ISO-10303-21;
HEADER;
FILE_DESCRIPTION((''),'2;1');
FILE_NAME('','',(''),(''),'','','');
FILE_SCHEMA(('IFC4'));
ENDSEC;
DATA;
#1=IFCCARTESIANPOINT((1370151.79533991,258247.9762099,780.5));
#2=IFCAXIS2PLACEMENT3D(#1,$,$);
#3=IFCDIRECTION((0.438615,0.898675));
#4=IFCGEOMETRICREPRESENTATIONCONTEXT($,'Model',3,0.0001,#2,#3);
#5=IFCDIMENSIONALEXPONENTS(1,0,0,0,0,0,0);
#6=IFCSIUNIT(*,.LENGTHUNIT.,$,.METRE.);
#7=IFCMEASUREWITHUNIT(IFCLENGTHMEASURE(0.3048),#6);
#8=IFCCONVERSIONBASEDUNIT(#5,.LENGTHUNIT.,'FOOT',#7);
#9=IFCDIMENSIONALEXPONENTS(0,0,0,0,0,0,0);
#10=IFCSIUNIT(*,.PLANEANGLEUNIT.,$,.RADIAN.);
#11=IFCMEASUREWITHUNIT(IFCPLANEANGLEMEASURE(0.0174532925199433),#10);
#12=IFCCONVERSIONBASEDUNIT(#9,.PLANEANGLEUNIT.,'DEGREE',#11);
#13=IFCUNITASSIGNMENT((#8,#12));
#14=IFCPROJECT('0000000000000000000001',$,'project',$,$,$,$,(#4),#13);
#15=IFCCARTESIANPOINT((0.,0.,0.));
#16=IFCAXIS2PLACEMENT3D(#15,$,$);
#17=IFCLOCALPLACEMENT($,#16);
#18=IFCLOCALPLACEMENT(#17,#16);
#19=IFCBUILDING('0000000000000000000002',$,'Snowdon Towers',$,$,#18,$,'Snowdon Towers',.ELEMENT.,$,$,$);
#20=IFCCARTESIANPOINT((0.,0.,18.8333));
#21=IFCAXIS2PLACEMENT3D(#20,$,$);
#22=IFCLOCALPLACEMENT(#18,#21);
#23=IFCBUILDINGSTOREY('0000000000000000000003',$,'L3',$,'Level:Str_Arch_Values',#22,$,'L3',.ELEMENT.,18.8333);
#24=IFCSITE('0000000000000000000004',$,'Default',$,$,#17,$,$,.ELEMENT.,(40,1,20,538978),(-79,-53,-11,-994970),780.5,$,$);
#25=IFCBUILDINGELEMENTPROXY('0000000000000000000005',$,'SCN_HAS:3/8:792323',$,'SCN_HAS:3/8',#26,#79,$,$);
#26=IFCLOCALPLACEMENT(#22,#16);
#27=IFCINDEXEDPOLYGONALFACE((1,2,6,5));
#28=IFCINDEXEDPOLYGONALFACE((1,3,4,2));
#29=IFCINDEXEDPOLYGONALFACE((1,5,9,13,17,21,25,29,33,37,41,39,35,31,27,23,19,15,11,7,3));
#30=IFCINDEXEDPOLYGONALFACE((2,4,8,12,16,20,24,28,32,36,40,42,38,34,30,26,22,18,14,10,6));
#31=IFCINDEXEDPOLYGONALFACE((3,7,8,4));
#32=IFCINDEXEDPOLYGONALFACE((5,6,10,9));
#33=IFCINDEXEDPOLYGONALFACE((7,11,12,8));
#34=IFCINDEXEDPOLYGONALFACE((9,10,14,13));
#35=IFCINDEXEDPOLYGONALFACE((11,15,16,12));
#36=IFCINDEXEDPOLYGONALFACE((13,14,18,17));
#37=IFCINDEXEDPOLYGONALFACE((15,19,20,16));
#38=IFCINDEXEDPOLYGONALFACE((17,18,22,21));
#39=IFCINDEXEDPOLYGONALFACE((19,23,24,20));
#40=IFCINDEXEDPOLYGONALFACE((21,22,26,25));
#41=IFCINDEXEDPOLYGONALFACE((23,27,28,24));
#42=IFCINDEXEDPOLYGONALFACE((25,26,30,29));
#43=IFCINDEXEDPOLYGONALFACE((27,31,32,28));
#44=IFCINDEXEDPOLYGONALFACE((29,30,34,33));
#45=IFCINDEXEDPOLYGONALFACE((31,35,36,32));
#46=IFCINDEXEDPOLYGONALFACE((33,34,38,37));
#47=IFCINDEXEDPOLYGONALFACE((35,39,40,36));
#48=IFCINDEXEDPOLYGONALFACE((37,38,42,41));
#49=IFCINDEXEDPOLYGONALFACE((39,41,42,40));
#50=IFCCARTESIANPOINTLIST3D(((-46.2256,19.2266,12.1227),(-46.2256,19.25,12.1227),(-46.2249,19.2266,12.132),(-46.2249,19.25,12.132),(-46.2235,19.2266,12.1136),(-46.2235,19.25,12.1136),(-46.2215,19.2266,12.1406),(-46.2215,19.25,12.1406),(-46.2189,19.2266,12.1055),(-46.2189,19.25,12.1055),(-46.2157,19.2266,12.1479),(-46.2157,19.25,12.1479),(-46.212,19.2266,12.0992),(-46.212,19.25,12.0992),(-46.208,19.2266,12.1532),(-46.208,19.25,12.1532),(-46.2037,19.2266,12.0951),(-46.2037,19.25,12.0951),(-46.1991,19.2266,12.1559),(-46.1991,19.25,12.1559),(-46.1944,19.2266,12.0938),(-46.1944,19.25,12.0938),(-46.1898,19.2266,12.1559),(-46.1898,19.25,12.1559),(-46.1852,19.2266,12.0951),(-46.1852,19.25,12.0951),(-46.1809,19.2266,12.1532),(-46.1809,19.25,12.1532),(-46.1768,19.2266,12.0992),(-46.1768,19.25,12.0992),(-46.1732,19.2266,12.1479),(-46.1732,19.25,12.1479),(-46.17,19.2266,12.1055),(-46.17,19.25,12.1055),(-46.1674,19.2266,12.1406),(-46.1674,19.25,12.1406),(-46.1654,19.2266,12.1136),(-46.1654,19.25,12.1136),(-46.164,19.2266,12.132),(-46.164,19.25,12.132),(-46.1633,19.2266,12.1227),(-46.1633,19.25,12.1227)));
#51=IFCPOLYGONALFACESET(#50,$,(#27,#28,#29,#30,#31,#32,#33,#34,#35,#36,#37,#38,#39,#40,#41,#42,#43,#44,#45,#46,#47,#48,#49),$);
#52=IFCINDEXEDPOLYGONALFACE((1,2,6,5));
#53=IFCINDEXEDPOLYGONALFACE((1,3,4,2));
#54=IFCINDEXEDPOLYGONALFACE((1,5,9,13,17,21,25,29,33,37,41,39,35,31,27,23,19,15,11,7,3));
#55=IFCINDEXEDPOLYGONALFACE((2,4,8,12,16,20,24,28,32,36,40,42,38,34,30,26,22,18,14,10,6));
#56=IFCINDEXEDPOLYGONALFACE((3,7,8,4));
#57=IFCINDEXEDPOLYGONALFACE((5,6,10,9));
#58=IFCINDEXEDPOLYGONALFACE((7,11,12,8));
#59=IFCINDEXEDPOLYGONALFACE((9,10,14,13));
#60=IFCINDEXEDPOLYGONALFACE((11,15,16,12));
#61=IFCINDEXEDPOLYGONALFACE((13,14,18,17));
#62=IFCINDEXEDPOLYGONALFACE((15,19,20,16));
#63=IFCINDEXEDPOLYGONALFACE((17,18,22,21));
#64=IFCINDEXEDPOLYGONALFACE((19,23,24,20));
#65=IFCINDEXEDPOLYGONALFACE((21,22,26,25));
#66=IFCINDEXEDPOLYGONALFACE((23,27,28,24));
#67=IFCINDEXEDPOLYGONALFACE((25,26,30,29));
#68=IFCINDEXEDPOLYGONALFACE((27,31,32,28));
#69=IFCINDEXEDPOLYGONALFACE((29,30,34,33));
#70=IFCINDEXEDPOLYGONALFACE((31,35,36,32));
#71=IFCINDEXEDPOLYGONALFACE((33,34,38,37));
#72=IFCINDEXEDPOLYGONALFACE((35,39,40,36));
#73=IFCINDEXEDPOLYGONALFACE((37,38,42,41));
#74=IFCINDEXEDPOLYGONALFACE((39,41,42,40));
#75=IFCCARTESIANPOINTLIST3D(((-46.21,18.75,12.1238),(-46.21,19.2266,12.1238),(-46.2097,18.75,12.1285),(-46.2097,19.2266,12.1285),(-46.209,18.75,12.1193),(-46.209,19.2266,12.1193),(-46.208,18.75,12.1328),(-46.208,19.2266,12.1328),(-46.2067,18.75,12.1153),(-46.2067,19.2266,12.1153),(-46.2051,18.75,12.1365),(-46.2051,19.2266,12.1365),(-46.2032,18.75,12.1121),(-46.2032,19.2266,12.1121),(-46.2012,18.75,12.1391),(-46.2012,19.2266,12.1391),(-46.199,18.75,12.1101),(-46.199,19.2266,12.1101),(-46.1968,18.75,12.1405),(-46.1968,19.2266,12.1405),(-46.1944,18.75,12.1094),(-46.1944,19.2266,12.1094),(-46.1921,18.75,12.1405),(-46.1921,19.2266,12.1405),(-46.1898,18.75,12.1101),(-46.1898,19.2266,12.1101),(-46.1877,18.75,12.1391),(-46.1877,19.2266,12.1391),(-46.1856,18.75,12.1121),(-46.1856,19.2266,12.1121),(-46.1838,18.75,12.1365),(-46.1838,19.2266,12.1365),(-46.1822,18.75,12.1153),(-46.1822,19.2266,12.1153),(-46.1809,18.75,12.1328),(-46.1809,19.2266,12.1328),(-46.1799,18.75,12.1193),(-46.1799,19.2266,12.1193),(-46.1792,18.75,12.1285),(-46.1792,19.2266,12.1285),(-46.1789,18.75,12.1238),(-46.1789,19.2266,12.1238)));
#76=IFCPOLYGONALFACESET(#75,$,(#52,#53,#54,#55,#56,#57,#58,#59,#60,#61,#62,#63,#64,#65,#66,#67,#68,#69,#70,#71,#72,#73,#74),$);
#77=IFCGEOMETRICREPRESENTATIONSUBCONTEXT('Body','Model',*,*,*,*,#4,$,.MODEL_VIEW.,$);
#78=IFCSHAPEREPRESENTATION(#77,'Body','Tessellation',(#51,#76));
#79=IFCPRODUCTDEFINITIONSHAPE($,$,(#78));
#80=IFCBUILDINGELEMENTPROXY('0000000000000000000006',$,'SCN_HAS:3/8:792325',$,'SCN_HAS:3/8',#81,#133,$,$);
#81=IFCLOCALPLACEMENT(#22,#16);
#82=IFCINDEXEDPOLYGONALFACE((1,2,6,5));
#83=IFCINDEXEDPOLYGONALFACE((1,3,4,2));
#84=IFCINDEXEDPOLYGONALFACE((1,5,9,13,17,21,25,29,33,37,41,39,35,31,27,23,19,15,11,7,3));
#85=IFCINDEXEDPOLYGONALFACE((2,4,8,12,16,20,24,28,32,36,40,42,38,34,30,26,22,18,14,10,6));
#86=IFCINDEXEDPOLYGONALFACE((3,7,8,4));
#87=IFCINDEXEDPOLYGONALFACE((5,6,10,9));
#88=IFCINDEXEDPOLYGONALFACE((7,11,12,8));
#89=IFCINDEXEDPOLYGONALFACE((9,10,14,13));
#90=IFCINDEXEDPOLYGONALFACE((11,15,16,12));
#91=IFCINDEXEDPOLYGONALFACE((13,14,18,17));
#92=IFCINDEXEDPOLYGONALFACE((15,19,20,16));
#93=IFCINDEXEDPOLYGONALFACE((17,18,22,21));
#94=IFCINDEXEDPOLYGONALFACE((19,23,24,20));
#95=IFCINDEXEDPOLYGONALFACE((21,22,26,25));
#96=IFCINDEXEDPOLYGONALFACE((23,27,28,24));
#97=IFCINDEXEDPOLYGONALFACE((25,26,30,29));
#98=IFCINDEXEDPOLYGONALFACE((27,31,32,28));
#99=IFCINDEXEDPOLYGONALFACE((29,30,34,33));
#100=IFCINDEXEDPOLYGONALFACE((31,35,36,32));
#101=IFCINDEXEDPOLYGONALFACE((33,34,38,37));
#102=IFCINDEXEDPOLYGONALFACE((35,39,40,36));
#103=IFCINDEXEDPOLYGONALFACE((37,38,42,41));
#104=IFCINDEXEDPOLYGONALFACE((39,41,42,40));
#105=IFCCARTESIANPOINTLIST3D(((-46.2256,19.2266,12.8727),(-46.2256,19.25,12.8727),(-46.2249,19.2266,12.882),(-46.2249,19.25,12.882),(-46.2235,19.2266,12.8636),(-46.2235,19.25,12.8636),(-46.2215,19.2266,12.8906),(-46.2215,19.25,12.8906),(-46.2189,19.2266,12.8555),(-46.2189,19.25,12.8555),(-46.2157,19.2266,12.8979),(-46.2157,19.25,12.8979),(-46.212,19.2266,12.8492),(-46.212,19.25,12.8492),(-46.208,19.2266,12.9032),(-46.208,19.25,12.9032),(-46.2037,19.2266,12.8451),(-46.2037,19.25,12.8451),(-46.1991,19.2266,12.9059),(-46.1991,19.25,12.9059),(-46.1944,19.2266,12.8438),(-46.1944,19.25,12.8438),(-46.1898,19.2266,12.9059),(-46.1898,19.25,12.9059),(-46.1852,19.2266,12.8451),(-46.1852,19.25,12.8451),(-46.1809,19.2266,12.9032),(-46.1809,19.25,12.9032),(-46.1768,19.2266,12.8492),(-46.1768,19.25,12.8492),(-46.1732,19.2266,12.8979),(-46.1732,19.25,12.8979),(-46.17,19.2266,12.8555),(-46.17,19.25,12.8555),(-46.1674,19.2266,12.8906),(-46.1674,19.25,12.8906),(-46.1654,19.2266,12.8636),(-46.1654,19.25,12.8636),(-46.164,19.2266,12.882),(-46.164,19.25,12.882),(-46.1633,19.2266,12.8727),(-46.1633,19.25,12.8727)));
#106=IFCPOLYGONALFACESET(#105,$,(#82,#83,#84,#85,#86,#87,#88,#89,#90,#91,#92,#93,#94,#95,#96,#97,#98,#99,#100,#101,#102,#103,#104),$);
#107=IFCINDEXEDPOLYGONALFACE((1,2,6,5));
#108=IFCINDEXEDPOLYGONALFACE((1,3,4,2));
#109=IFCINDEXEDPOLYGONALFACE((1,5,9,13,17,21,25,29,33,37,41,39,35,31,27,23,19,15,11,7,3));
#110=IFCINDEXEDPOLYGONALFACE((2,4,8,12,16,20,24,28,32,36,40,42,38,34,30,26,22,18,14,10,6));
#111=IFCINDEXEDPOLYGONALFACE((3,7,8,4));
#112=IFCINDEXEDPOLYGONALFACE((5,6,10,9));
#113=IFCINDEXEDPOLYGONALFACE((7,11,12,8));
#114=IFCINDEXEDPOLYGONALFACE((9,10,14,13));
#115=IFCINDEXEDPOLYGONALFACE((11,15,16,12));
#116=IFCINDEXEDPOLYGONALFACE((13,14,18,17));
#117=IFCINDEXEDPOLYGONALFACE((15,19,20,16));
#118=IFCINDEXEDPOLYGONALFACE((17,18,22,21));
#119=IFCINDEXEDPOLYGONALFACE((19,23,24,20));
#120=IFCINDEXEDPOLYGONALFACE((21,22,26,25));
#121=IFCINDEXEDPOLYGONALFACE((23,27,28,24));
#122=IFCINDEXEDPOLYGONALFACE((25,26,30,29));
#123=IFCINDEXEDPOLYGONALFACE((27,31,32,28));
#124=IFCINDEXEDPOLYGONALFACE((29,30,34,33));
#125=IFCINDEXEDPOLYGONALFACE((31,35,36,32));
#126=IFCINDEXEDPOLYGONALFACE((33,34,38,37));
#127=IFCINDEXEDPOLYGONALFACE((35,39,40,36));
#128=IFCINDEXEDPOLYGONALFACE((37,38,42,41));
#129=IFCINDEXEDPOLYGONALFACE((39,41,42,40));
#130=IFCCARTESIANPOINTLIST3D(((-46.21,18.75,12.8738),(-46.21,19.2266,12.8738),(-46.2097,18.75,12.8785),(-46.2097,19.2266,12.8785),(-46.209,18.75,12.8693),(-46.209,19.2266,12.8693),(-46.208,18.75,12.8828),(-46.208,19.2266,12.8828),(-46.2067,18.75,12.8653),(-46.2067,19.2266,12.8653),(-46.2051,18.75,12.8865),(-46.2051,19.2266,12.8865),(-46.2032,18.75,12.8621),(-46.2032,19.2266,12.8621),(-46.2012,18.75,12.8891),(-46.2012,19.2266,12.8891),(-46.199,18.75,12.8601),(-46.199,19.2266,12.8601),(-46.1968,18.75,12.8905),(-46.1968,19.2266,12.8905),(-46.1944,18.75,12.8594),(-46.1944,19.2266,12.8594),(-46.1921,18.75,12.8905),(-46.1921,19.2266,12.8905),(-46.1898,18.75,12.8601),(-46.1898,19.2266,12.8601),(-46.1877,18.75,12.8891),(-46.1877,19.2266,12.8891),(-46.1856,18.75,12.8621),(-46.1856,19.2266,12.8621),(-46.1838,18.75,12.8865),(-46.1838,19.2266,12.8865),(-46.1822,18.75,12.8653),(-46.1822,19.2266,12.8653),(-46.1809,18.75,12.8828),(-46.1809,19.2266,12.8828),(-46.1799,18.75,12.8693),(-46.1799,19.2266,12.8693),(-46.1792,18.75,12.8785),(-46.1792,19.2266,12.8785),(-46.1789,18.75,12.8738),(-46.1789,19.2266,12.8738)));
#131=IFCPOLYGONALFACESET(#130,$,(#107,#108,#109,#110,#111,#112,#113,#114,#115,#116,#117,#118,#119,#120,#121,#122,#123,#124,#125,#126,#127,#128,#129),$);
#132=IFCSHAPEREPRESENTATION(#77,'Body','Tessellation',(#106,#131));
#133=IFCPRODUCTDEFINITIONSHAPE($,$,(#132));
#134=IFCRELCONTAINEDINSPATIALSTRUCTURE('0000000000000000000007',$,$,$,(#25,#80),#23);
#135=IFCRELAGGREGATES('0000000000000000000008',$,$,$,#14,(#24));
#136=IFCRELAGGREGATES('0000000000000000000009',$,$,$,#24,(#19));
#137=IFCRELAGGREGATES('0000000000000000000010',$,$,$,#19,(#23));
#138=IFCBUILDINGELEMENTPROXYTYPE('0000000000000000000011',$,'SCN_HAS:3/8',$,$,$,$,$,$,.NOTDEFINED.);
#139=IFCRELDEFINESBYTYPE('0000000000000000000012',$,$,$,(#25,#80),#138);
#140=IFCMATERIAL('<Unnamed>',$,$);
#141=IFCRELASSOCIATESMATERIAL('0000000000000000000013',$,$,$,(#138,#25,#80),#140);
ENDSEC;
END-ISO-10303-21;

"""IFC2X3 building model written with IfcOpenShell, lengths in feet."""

from ifc_helpers import new_model, entity, si_unit, converted_unit, direction, frame, frame_2d, origin, place, context, subcontext, project, spatial, circle, extrude, source, transform, mapped, material, type_object, type_shapes, element, save


model = new_model("IFC2X3")

# Units and contexts
model_context = context("Model", 3, precision=0.0001, world=frame((1370151.79533991, 258247.9762099, 780.5)), true_north=direction((0.438615, 0.898675)))
body_context = subcontext(model_context, "Body", "Model", "MODEL_VIEW")
ifc_project = project(units=[converted_unit("LENGTHUNIT", "FOOT", entity("IfcLengthMeasure", 0.3048), si_unit("LENGTHUNIT", "METRE"), dimensions=[1, 0, 0, 0, 0, 0, 0]), converted_unit("PLANEANGLEUNIT", "DEGREE", entity("IfcPlaneAngleMeasure", 0.0174532925199433), si_unit("PLANEANGLEUNIT", "RADIAN"), dimensions=[0, 0, 0, 0, 0, 0, 0])], contexts=[model_context])

# Site, building, storey
site_placement = place(None, origin())
site = spatial("IfcSite", under=ifc_project, at=site_placement, Name="Default", CompositionType="ELEMENT", RefLatitude=(40, 1, 20, 538978), RefLongitude=(-79, -53, -11, -994970), RefElevation=780.5)
building_placement = place(site_placement, origin())
building = spatial("IfcBuilding", under=site, at=building_placement, Name="Snowdon Towers", LongName="Snowdon Towers", CompositionType="ELEMENT")
storey_placement = place(building_placement, frame((0.0, 0.0, 18.8333)))
storey = spatial("IfcBuildingStorey", under=building, at=storey_placement, Name="L3", ObjectType="Level:Str_Arch_Values", LongName="L3", CompositionType="ELEMENT", Elevation=18.8333)

# Building element proxies
ifc_material_1 = material(Name="<Unnamed>")
building_element_proxy_type_1 = type_object("IfcBuildingElementProxyType", Name="SCN_HAS:3/8", PredefinedType="NOTDEFINED", material=ifc_material_1)
shared_shape_1 = source(origin(), body_context, "Body", "SweptSolid", [
    extrude(circle(Radius=0.0312, at=frame_2d((0.0, 0.0), x_axis=(1.0, 0.0))), frame((0.0, 0.0, -0.5), z_axis=(0.0, 0.0, 1.0), x_axis=(0.0, -1.0, 0.0)), (0.0, 0.0, 1.0), 0.0234),
    extrude(circle(Radius=0.0156, at=frame_2d((0.0, 0.0), x_axis=(1.0, 0.0))), frame((0.0, 0.0, -0.4766), z_axis=(0.0, 0.0, 1.0), x_axis=(0.0, -1.0, 0.0)), (0.0, 0.0, 1.0), 0.4766),
])
type_shapes(building_element_proxy_type_1, [shared_shape_1])
for number, where, z_axis, x_axis, name in (
    (1, (-46.1944, 18.75, 12.125), (0.0, -1.0, 0.0), (1.0, 0.0, 0.0), "SCN_HAS:3/8:792323"),
    (2, (-46.1944, 18.75, 12.875), (0.0, -1.0, 0.0), (1.0, 0.0, 0.0), "SCN_HAS:3/8:792325"),
):
    element("IfcBuildingElementProxy", number, at=place(storey_placement, frame(where, z_axis=z_axis, x_axis=x_axis)), inside=storey, type_object=building_element_proxy_type_1, material=ifc_material_1, Name=name, ObjectType="SCN_HAS:3/8", context=body_context, shape_type="MappedRepresentation", body=[
        mapped(shared_shape_1, transform((0.0, 0.0, 0.0), scale=1.0)),
    ])

save(model, "model.ifc")
